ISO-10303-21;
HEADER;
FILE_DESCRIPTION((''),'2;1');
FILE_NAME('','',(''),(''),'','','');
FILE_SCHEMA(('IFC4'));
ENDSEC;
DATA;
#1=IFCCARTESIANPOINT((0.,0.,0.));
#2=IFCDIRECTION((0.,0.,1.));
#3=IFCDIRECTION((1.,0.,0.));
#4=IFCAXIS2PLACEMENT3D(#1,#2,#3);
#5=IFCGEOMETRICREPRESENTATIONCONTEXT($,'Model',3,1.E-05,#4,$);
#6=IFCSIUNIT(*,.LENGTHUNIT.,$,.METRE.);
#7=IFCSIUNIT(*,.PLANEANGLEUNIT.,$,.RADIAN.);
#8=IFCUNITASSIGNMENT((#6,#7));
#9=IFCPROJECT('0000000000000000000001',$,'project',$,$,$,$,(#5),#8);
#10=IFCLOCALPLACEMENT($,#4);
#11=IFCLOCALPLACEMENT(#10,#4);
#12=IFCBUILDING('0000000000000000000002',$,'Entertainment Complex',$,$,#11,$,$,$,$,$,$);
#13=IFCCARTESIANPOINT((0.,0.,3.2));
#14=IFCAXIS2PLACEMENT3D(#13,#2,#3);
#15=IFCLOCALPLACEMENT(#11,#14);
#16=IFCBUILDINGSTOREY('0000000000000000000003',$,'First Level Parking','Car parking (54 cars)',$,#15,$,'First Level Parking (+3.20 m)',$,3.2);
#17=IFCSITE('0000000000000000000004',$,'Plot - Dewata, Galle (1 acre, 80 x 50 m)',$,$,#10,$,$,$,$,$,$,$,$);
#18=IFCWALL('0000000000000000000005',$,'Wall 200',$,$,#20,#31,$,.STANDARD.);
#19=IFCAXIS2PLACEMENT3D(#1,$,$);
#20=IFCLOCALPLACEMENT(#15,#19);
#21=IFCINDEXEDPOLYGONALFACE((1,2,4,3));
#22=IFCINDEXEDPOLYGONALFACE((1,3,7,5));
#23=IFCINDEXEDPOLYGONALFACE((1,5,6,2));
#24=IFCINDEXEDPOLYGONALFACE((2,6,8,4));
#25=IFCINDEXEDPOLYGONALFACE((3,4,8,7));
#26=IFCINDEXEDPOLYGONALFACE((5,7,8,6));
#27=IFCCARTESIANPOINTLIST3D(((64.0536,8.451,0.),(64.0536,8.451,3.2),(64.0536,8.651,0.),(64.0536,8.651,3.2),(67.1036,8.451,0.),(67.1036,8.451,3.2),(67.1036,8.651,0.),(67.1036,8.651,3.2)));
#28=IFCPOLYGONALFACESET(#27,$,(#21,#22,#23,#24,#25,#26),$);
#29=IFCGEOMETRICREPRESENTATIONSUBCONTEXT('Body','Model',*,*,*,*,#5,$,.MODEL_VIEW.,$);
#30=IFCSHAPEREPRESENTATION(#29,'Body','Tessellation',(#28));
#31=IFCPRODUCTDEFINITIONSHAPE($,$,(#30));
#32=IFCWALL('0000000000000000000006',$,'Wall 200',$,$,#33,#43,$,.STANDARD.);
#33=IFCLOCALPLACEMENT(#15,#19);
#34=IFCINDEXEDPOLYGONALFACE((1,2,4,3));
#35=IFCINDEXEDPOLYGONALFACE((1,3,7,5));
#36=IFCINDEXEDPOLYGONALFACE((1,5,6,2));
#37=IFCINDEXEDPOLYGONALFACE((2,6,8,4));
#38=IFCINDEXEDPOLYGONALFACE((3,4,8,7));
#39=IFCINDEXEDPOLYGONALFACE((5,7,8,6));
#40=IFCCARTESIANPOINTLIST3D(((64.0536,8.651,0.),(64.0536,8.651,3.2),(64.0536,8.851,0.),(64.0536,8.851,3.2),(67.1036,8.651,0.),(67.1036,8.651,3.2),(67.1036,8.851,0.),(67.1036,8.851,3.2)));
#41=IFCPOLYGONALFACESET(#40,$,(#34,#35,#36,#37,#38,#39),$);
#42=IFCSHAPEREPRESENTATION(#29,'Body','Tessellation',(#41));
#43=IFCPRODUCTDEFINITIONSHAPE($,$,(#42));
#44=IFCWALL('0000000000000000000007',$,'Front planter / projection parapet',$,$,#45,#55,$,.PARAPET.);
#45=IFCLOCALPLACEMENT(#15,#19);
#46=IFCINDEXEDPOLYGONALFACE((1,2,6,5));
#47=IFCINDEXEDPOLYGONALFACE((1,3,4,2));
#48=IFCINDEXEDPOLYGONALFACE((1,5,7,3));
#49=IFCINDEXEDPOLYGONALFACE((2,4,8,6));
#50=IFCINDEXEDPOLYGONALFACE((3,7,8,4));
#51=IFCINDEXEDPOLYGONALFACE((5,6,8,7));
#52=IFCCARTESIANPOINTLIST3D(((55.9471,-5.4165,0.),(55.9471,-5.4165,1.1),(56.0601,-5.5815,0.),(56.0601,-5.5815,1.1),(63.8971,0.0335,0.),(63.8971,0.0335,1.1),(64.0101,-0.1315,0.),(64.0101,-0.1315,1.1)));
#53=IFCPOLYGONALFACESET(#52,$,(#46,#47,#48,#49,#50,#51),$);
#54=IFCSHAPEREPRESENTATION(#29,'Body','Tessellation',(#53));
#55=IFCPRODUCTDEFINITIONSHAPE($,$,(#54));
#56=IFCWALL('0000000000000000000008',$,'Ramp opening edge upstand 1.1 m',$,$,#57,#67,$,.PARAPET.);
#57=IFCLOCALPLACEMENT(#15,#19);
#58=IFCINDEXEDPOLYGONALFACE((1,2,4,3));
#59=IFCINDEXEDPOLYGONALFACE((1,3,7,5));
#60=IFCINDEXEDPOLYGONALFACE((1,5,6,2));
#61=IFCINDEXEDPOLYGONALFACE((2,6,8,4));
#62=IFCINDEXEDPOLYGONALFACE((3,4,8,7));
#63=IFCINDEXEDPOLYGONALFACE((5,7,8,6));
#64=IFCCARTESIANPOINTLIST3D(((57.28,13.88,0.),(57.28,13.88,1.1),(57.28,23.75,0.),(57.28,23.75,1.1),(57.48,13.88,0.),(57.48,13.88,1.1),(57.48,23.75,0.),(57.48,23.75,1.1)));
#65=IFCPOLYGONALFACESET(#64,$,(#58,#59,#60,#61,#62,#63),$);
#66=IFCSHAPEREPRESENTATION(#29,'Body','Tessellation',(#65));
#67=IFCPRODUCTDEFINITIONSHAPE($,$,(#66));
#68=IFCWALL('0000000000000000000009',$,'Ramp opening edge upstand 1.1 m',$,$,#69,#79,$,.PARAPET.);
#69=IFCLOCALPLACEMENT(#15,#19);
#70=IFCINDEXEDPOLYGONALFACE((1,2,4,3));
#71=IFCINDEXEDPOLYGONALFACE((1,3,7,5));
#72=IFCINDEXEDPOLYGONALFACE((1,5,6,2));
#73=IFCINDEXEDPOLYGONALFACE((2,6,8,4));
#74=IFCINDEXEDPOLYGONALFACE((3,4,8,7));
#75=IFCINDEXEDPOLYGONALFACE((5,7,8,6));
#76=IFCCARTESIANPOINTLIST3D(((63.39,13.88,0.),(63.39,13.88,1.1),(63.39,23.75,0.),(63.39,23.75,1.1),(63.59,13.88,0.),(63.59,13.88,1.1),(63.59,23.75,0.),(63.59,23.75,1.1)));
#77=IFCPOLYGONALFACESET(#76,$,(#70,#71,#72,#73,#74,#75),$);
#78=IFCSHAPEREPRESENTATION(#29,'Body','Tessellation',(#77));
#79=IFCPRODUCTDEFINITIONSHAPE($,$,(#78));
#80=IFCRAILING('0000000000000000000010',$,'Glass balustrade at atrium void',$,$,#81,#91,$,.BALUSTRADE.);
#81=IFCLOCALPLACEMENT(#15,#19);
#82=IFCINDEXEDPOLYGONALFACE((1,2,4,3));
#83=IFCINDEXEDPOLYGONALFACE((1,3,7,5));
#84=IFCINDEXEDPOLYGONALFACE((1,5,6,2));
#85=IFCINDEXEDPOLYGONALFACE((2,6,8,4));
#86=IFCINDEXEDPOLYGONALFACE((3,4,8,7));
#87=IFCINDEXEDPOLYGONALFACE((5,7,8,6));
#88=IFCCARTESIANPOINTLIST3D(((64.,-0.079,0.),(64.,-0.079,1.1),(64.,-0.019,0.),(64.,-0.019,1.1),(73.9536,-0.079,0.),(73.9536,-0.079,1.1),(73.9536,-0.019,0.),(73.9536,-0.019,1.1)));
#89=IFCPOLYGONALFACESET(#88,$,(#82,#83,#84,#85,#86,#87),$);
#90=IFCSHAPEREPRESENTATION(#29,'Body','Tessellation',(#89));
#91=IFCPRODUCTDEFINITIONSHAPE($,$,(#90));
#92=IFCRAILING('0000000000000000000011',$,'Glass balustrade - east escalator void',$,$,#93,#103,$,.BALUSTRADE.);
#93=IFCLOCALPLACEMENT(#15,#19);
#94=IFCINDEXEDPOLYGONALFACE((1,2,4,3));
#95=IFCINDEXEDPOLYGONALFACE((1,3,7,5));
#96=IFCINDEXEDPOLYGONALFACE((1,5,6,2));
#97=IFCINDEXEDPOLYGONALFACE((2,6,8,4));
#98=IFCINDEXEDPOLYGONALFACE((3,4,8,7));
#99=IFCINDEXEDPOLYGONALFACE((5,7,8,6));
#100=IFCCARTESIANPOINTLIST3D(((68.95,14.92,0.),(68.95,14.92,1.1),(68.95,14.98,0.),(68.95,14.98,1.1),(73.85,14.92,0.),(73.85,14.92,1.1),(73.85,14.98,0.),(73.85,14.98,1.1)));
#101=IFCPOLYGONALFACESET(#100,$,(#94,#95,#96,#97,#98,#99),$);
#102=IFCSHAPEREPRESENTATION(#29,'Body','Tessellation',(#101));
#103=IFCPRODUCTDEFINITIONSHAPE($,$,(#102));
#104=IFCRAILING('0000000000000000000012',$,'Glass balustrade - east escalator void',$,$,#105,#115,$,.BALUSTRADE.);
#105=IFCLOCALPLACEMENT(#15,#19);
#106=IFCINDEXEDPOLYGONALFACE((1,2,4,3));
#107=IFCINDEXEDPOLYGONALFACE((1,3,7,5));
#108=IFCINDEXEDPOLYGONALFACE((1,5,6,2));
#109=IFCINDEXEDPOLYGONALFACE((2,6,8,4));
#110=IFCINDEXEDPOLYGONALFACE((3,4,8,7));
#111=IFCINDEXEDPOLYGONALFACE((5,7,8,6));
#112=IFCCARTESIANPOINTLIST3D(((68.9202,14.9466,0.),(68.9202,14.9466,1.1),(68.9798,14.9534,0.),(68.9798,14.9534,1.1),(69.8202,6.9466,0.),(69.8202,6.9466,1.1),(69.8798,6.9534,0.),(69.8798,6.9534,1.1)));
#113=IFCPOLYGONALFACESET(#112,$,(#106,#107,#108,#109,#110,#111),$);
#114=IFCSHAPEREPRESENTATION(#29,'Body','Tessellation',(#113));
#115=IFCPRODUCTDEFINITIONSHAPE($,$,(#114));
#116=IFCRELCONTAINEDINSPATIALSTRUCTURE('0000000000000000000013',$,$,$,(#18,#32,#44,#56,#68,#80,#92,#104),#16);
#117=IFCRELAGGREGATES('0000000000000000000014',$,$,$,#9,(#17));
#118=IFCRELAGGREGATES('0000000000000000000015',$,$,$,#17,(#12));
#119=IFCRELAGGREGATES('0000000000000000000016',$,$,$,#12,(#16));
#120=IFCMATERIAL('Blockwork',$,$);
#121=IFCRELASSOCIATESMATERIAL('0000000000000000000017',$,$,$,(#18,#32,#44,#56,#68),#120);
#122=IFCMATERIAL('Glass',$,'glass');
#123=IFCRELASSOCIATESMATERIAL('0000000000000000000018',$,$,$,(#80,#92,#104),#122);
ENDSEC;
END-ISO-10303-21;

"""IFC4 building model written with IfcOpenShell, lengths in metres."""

from ifc_helpers import new_model, si_unit, frame, origin_with_axes, place, context, subcontext, project, spatial, polyline, outline, extrude, material, element, save


model = new_model("IFC4")

# Units and contexts
model_context = context("Model", 3, precision=1e-05, world=origin_with_axes())
body_context = subcontext(model_context, "Body", "Model", "MODEL_VIEW")
ifc_project = project(units=[si_unit("LENGTHUNIT", "METRE"), si_unit("PLANEANGLEUNIT", "RADIAN")], contexts=[model_context])

# Site, building, storey
site_placement = place(None, origin_with_axes())
site = spatial("IfcSite", under=ifc_project, at=site_placement, Name="Plot - Dewata, Galle (1 acre, 80 x 50 m)")
building_placement = place(site_placement, origin_with_axes())
building = spatial("IfcBuilding", under=site, at=building_placement, Name="Entertainment Complex")
storey_placement = place(building_placement, frame((0.0, 0.0, 3.2), z_axis=(0.0, 0.0, 1.0), x_axis=(1.0, 0.0, 0.0)))
storey = spatial("IfcBuildingStorey", under=building, at=storey_placement, Name="First Level Parking", Description="Car parking (54 cars)", LongName="First Level Parking (+3.20 m)", Elevation=3.2)

# Shared definitions
ifc_material_1 = material(Name="Blockwork")

# Walls
for number, where, z_axis, x_axis, name in (
    (1, (64.0536, 8.551, 0.0), (0.0, 0.0, 1.0), (1.0, 0.0, 0.0), "Wall 200"),
    (2, (64.0536, 8.751, 0.0), (0.0, 0.0, 1.0), (1.0, 0.0, 0.0), "Wall 200"),
):
    element("IfcWall", number, at=place(storey_placement, frame(where, z_axis=z_axis, x_axis=x_axis)), inside=storey, material=ifc_material_1, Name=name, PredefinedType="STANDARD", context=body_context, shape_type="SweptSolid", body=[
        extrude(outline(polyline([(0.0, -0.1), (3.05, -0.1), (3.05, 0.1), (0.0, 0.1), (0.0, -0.1)])), origin_with_axes(), (0.0, 0.0, 1.0), 3.2),
    ])
wall_1_placement = place(storey_placement, frame((56.0036, -5.499, 0.0), z_axis=(0.0, 0.0, 1.0), x_axis=(0.824798, 0.565428, 0.0)))
element("IfcWall", 3, at=wall_1_placement, inside=storey, material=ifc_material_1, Name="Front planter / projection parapet", PredefinedType="PARAPET", context=body_context, shape_type="SweptSolid", body=[
    extrude(outline(polyline([(0.0, -0.1), (9.6387, -0.1), (9.6387, 0.1), (0.0, 0.1), (0.0, -0.1)])), origin_with_axes(), (0.0, 0.0, 1.0), 1.1),
])
for number, where, z_axis, x_axis, name in (
    (4, (57.38, 13.88, 0.0), (0.0, 0.0, 1.0), (0.0, 1.0, 0.0), "Ramp opening edge upstand 1.1 m"),
    (5, (63.49, 13.88, 0.0), (0.0, 0.0, 1.0), (0.0, 1.0, 0.0), "Ramp opening edge upstand 1.1 m"),
):
    element("IfcWall", number, at=place(storey_placement, frame(where, z_axis=z_axis, x_axis=x_axis)), inside=storey, material=ifc_material_1, Name=name, PredefinedType="PARAPET", context=body_context, shape_type="SweptSolid", body=[
        extrude(outline(polyline([(0.0, -0.1), (9.87, -0.1), (9.87, 0.1), (0.0, 0.1), (0.0, -0.1)])), origin_with_axes(), (0.0, 0.0, 1.0), 1.1),
    ])

# Railings
ifc_material_2 = material(Name="Glass", Category="glass")
railing_1_placement = place(storey_placement, frame((64.0, -0.049, 0.0), z_axis=(0.0, 0.0, 1.0), x_axis=(1.0, 0.0, 0.0)))
element("IfcRailing", 6, at=railing_1_placement, inside=storey, material=ifc_material_2, Name="Glass balustrade at atrium void", PredefinedType="BALUSTRADE", context=body_context, shape_type="SweptSolid", body=[
    extrude(outline(polyline([(0.0, -0.03), (9.9536, -0.03), (9.9536, 0.03), (0.0, 0.03), (0.0, -0.03)])), origin_with_axes(), (0.0, 0.0, 1.0), 1.1),
])
railing_2_placement = place(storey_placement, frame((68.95, 14.95, 0.0), z_axis=(0.0, 0.0, 1.0), x_axis=(1.0, 0.0, 0.0)))
element("IfcRailing", 7, at=railing_2_placement, inside=storey, material=ifc_material_2, Name="Glass balustrade - east escalator void", PredefinedType="BALUSTRADE", context=body_context, shape_type="SweptSolid", body=[
    extrude(outline(polyline([(0.0, -0.03), (4.9, -0.03), (4.9, 0.03), (0.0, 0.03), (0.0, -0.03)])), origin_with_axes(), (0.0, 0.0, 1.0), 1.1),
])
railing_3_placement = place(storey_placement, frame((69.85, 6.95, 0.0), z_axis=(0.0, 0.0, 1.0), x_axis=(-0.111795, 0.993731, 0.0)))
element("IfcRailing", 8, at=railing_3_placement, inside=storey, material=ifc_material_2, Name="Glass balustrade - east escalator void", PredefinedType="BALUSTRADE", context=body_context, shape_type="SweptSolid", body=[
    extrude(outline(polyline([(0.0, -0.03), (8.0505, -0.03), (8.0505, 0.03), (0.0, 0.03), (0.0, -0.03)])), origin_with_axes(), (0.0, 0.0, 1.0), 1.1),
])

save(model, "model.ifc")
